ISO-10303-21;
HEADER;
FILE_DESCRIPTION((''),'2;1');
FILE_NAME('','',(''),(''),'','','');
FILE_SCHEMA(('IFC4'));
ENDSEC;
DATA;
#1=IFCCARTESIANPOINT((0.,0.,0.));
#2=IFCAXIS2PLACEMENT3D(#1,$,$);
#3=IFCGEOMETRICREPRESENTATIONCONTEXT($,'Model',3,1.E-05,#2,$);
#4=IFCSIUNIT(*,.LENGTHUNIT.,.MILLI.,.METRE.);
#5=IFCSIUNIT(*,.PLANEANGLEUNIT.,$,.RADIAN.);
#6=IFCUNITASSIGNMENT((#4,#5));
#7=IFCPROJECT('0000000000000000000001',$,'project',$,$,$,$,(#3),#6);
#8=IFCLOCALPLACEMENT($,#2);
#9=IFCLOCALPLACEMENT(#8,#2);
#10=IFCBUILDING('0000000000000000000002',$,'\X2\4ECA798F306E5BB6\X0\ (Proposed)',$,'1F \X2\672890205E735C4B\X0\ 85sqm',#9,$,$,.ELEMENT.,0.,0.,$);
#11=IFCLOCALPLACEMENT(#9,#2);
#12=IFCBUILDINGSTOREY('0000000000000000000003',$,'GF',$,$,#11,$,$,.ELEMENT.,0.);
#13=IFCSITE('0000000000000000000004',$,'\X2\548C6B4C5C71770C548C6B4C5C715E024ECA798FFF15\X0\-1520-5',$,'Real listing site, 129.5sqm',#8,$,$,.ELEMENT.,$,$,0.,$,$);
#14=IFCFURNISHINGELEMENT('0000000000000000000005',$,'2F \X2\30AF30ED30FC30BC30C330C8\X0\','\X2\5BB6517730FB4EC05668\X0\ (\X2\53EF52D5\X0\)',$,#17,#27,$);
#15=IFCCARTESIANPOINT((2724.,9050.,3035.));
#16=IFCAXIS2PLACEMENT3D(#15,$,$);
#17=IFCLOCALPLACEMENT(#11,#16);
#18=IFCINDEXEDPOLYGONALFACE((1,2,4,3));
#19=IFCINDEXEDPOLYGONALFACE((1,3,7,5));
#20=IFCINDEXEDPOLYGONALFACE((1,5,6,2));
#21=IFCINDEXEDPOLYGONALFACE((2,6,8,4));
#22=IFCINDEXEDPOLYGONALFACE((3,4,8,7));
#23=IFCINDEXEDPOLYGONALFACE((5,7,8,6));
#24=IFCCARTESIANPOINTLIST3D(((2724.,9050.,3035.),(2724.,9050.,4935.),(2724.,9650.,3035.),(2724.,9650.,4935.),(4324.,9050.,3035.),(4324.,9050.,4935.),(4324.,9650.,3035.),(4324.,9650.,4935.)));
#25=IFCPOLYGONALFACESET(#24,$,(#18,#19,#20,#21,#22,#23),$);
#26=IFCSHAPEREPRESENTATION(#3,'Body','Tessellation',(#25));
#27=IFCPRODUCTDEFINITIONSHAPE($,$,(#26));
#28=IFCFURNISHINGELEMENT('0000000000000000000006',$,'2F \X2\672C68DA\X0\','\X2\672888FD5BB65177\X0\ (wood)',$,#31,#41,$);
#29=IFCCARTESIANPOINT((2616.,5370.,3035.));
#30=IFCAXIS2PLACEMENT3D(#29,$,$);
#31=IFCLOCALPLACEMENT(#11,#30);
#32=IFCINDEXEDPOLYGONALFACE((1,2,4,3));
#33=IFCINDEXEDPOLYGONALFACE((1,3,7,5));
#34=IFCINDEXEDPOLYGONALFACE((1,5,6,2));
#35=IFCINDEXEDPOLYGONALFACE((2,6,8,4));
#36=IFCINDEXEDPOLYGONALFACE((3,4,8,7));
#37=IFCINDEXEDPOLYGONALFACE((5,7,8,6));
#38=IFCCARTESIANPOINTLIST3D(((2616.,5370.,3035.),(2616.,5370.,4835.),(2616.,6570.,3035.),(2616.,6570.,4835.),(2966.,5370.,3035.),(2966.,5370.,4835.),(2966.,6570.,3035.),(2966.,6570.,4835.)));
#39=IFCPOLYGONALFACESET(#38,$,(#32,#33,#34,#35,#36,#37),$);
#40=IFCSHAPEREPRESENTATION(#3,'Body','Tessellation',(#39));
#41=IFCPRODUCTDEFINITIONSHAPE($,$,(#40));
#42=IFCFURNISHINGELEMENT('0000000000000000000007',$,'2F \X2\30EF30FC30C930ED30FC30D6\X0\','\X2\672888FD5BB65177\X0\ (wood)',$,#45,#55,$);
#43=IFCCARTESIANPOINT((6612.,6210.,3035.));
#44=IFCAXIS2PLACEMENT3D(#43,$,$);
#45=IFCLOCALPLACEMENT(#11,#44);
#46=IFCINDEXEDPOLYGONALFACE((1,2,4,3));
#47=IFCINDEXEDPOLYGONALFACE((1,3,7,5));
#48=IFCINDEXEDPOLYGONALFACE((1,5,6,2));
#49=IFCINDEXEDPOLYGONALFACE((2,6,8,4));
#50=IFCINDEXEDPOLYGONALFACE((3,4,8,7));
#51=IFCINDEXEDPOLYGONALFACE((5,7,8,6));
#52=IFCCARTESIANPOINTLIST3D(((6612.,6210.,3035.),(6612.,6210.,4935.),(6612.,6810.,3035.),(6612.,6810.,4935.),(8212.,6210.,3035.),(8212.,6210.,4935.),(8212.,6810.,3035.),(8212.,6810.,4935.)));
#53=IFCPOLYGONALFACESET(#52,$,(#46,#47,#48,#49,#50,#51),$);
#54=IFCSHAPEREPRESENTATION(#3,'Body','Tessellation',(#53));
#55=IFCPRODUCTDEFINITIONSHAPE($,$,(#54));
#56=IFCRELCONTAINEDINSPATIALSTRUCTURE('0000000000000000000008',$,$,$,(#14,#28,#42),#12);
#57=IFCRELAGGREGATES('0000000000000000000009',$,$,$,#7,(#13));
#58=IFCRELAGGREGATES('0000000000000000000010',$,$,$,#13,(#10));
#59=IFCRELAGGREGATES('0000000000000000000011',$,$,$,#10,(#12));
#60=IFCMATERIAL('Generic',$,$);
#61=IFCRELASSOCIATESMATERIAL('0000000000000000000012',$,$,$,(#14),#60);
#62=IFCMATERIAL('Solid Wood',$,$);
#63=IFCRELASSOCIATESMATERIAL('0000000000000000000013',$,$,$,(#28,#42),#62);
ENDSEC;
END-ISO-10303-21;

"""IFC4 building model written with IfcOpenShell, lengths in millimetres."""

from ifc_helpers import new_model, si_unit, frame, frame_2d, origin, place, context, project, spatial, rectangle, extrude, material, element, save


model = new_model("IFC4")

# Units and contexts
model_context = context("Model", 3, precision=1e-05, world=origin())
ifc_project = project(units=[si_unit("LENGTHUNIT", "METRE", prefix="MILLI"), si_unit("PLANEANGLEUNIT", "RADIAN")], contexts=[model_context])

# Site, building, storey
site_placement = place(None, origin())
site = spatial("IfcSite", under=ifc_project, at=site_placement, Name="和歌山県和歌山市今福５-1520-5", ObjectType="Real listing site, 129.5sqm", CompositionType="ELEMENT", RefElevation=0.0)
building_placement = place(site_placement, origin())
building = spatial("IfcBuilding", under=site, at=building_placement, Name="今福の家 (Proposed)", ObjectType="1F 木造平屋 85sqm", CompositionType="ELEMENT", ElevationOfRefHeight=0.0, ElevationOfTerrain=0.0)
storey_placement = place(building_placement, origin())
storey = spatial("IfcBuildingStorey", under=building, at=storey_placement, Name="GF", CompositionType="ELEMENT", Elevation=0.0)

# Shared definitions
ifc_material_1 = material(Name="Solid Wood")

# Shared definitions
ifc_material_2 = material(Name="Generic")

# Furnishing elements
furnishing_1_placement = place(storey_placement, frame((2724.0, 9050.0, 3035.0)))
element("IfcFurnishingElement", 1, at=furnishing_1_placement, inside=storey, material=ifc_material_2, Name="2F クローゼット", Description="家具・什器 (可動)", context=model_context, shape_type="SweptSolid", body=[
    extrude(rectangle(XDim=1600.0, YDim=600.0, at=frame_2d((800.0, 300.0))), frame((2724.0, 9050.0, 3035.0)), (0.0, 0.0, 1.0), 1900.0),
])
furnishing_2_placement = place(storey_placement, frame((2616.0, 5370.0, 3035.0)))
element("IfcFurnishingElement", 2, at=furnishing_2_placement, inside=storey, material=ifc_material_1, Name="2F 本棚", Description="木製家具 (wood)", context=model_context, shape_type="SweptSolid", body=[
    extrude(rectangle(XDim=350.0, YDim=1200.0, at=frame_2d((175.0, 600.0))), frame((2616.0, 5370.0, 3035.0)), (0.0, 0.0, 1.0), 1800.0),
])
furnishing_3_placement = place(storey_placement, frame((6612.0, 6210.0, 3035.0)))
element("IfcFurnishingElement", 3, at=furnishing_3_placement, inside=storey, material=ifc_material_1, Name="2F ワードローブ", Description="木製家具 (wood)", context=model_context, shape_type="SweptSolid", body=[
    extrude(rectangle(XDim=1600.0, YDim=600.0, at=frame_2d((800.0, 300.0))), frame((6612.0, 6210.0, 3035.0)), (0.0, 0.0, 1.0), 1900.0),
])

save(model, "model.ifc")
